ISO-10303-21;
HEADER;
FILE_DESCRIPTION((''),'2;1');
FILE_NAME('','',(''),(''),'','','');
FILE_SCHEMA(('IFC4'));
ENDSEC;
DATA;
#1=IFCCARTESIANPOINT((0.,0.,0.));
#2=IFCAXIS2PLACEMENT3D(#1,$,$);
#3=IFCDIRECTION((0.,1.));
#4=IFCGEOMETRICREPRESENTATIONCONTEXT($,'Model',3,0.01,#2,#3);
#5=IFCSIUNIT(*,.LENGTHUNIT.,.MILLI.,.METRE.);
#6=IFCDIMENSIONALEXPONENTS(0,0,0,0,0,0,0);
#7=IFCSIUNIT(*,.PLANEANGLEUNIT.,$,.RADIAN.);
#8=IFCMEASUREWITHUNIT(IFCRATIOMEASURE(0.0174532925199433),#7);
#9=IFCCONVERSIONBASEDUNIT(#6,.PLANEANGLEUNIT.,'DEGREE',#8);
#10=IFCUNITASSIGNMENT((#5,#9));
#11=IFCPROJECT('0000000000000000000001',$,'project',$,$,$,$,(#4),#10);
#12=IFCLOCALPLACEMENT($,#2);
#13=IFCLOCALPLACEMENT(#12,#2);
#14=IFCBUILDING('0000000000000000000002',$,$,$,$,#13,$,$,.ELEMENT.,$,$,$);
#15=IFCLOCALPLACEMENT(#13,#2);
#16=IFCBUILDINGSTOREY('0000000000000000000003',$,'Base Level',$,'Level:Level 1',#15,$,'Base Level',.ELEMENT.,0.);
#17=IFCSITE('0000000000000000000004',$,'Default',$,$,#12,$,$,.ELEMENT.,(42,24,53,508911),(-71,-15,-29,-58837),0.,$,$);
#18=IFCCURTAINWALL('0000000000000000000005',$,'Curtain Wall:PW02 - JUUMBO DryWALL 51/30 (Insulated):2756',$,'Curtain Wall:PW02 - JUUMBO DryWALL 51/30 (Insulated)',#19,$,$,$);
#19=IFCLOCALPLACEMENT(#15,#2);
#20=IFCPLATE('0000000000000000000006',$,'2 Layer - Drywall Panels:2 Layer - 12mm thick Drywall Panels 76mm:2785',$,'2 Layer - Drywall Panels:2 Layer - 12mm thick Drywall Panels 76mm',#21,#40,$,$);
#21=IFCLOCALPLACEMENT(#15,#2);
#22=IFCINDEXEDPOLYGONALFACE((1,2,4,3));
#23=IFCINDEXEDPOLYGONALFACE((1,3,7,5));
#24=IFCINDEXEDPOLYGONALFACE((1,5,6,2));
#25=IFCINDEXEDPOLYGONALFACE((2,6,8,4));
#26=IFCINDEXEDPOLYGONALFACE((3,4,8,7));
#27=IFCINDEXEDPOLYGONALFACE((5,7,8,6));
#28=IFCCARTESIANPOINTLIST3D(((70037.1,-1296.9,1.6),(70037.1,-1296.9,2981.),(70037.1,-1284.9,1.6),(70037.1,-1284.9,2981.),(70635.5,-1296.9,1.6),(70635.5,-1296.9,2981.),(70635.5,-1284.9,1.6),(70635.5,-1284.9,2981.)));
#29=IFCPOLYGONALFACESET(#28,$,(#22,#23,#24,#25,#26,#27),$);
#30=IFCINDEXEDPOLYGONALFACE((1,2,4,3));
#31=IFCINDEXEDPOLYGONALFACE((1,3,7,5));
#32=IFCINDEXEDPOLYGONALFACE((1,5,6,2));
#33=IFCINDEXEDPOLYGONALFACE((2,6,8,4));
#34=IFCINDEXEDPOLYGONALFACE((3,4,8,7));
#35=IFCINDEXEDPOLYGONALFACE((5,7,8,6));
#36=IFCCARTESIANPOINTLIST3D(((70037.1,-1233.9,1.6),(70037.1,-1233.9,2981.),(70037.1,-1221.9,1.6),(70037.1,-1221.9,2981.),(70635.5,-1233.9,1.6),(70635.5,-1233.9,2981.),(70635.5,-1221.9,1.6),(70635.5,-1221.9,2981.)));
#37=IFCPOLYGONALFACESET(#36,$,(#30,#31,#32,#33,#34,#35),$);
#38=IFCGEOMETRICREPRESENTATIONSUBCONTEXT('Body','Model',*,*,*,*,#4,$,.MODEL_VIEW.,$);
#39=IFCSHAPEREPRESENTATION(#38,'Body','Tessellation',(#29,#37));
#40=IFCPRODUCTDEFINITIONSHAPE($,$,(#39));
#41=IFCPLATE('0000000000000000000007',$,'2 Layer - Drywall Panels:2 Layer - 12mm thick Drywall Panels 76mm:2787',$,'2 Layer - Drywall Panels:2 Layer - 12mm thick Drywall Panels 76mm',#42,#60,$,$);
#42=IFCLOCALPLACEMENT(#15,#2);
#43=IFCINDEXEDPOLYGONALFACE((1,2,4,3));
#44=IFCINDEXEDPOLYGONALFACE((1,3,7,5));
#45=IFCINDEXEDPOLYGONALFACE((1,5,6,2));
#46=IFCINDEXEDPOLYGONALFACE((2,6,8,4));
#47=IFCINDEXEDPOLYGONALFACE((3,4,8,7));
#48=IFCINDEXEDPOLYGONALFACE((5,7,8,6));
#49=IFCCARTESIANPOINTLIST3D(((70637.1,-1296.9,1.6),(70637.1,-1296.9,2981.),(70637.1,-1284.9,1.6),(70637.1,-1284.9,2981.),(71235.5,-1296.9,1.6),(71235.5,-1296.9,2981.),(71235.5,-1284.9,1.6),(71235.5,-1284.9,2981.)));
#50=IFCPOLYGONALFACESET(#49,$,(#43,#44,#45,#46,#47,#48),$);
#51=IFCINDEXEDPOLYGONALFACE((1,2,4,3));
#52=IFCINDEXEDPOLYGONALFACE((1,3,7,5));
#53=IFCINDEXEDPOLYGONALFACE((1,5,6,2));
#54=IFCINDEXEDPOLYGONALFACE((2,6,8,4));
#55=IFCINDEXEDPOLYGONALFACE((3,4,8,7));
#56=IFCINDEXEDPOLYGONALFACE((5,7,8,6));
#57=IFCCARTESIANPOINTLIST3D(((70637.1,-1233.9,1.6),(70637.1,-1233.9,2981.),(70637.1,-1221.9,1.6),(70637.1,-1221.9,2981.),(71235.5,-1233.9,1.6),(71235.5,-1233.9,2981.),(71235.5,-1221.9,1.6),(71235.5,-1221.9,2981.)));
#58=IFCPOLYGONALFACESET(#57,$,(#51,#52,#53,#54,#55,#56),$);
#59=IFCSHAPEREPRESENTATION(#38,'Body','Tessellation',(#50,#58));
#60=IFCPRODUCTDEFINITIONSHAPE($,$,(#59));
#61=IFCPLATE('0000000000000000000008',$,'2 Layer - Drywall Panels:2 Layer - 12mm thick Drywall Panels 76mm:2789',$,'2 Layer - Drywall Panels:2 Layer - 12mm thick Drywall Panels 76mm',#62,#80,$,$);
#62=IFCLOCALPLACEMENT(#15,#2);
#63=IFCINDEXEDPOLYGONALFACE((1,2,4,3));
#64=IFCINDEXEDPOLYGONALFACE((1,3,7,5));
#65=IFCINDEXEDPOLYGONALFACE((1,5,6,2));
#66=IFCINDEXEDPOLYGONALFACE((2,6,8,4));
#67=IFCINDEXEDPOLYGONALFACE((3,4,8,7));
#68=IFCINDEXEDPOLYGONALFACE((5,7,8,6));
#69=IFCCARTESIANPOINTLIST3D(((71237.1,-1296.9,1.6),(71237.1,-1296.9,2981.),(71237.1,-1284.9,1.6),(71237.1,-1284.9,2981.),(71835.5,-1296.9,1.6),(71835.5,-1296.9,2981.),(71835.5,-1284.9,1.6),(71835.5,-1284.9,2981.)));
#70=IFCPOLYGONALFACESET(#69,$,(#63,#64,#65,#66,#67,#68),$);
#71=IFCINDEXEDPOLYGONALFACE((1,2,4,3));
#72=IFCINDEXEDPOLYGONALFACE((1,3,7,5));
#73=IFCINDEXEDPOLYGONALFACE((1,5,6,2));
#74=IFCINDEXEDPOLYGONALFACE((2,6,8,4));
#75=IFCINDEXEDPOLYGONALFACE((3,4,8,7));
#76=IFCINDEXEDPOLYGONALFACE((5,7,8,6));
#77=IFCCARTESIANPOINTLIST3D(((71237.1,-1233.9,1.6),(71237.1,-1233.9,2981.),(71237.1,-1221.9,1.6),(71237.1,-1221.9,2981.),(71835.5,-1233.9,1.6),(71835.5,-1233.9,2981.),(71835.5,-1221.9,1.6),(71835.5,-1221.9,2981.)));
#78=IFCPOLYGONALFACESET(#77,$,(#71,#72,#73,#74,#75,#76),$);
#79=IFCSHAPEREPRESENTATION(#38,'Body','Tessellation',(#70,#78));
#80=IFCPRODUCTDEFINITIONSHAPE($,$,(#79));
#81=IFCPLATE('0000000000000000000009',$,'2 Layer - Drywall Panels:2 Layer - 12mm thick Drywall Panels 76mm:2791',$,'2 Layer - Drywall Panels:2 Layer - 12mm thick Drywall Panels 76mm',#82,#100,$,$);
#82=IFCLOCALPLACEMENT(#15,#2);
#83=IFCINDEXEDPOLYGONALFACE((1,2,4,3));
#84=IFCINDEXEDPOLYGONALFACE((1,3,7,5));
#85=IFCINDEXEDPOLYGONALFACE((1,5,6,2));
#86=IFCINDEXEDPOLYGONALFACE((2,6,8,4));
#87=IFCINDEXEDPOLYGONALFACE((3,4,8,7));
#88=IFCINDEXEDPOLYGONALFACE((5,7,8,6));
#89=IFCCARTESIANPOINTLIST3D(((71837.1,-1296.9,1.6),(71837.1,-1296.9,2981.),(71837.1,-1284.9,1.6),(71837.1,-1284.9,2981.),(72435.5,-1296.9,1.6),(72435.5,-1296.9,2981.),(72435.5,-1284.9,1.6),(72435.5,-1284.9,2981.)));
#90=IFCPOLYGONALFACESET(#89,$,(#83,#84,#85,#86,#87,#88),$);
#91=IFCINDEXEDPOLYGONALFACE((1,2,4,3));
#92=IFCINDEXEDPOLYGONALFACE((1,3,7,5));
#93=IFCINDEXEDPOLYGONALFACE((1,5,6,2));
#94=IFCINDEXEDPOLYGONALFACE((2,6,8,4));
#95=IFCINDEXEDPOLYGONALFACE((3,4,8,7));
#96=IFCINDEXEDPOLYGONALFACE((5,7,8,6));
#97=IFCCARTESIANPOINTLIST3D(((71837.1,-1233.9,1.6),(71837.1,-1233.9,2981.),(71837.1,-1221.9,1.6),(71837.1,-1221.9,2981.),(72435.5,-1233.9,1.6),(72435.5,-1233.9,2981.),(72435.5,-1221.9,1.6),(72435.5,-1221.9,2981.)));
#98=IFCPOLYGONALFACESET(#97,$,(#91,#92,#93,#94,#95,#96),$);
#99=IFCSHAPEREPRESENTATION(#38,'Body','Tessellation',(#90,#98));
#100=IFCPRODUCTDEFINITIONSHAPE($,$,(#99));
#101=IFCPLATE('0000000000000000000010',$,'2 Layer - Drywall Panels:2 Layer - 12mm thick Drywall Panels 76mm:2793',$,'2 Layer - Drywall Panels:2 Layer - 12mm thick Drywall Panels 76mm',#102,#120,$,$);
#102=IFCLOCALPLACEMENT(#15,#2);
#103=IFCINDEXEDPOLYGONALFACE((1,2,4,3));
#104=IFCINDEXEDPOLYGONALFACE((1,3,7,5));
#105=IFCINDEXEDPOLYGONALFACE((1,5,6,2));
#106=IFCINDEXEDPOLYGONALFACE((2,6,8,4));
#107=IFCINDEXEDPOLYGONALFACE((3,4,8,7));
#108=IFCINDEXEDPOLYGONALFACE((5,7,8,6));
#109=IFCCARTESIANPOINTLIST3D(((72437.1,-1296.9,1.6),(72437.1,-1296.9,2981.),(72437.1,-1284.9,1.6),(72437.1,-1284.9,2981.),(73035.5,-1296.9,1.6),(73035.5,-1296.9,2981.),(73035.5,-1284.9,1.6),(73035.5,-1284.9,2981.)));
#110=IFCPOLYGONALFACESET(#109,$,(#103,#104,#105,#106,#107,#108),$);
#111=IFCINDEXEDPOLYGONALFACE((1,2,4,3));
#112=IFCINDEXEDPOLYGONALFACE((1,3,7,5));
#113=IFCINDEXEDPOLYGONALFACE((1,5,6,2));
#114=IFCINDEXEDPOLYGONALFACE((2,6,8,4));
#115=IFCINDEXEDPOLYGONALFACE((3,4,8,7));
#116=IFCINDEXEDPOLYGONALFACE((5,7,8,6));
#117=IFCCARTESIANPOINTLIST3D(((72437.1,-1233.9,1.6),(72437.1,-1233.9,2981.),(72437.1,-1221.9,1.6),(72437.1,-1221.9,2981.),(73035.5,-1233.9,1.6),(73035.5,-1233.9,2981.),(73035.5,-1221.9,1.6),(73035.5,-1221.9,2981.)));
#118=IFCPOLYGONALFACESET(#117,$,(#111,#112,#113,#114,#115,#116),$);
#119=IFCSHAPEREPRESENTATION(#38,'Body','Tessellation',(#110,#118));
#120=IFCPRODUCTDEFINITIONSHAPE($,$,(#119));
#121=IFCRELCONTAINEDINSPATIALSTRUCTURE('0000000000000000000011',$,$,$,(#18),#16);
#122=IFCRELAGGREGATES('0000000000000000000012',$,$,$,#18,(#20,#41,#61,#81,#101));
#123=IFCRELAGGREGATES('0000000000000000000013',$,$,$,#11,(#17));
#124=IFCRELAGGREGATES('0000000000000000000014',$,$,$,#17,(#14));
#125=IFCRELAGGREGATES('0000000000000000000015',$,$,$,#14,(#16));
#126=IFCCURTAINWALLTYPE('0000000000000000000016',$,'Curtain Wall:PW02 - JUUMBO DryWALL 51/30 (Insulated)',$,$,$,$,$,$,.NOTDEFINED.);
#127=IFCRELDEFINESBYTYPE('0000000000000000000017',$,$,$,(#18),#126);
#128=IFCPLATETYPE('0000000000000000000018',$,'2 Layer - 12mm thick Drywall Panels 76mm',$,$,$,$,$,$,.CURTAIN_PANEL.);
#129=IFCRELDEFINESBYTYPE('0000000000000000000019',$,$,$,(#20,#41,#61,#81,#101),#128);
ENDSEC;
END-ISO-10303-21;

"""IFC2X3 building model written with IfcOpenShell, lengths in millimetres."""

from ifc_helpers import new_model, entity, si_unit, converted_unit, direction, frame, frame_2d, origin, origin_2d_with_axis, place, context, subcontext, project, spatial, rectangle, extrude, source, transform, mapped, type_object, type_shapes, element, aggregate, save


model = new_model("IFC2X3")

# Units and contexts
model_context = context("Model", 3, precision=0.01, world=origin(), true_north=direction((0.0, 1.0)))
body_context = subcontext(model_context, "Body", "Model", "MODEL_VIEW")
ifc_project = project(units=[si_unit("LENGTHUNIT", "METRE", prefix="MILLI"), converted_unit("PLANEANGLEUNIT", "DEGREE", entity("IfcRatioMeasure", 0.0174532925199433), si_unit("PLANEANGLEUNIT", "RADIAN"), dimensions=[0, 0, 0, 0, 0, 0, 0])], contexts=[model_context])

# Site, building, storey
site_placement = place(None, origin())
site = spatial("IfcSite", under=ifc_project, at=site_placement, Name="Default", CompositionType="ELEMENT", RefLatitude=(42, 24, 53, 508911), RefLongitude=(-71, -15, -29, -58837), RefElevation=0.0)
building_placement = place(site_placement, origin())
building = spatial("IfcBuilding", under=site, at=building_placement, CompositionType="ELEMENT")
storey_placement = place(building_placement, origin())
storey = spatial("IfcBuildingStorey", under=building, at=storey_placement, Name="Base Level", ObjectType="Level:Level 1", LongName="Base Level", CompositionType="ELEMENT", Elevation=0.0)

# Curtain wall, plates
curtain_wall_type = type_object("IfcCurtainWallType", Name="Curtain Wall:PW02 - JUUMBO DryWALL 51/30 (Insulated)", PredefinedType="NOTDEFINED")
curtain_wall_placement = place(building_placement, origin())
curtain_wall = element("IfcCurtainWall", 1, at=curtain_wall_placement, inside=storey, type_object=curtain_wall_type, Name="Curtain Wall:PW02 - JUUMBO DryWALL 51/30 (Insulated):2756", ObjectType="Curtain Wall:PW02 - JUUMBO DryWALL 51/30 (Insulated)")
plate_type = type_object("IfcPlateType", Name="2 Layer - 12mm thick Drywall Panels 76mm", PredefinedType="CURTAIN_PANEL")
shared_shape_1 = source(origin(), body_context, "Body", "SweptSolid", [
    extrude(rectangle(XDim=598.4, YDim=12.0, at=origin_2d_with_axis()), frame((0.0, -31.5, 0.0), z_axis=(0.0, 0.0, 1.0), x_axis=(-1.0, 0.0, 0.0)), (0.0, 0.0, 1.0), 2979.4),
    extrude(rectangle(XDim=12.0, YDim=598.4, at=frame_2d((0.0, 0.0), x_axis=(1.0, 0.0))), frame((0.0, 31.5, 0.0), z_axis=(0.0, 0.0, 1.0), x_axis=(0.0, 1.0, 0.0)), (0.0, 0.0, 1.0), 2979.4),
])
type_shapes(plate_type, [shared_shape_1])
plate_1_placement = place(curtain_wall_placement, frame((70336.3, -1259.4, 1.6)))
plate_1 = element("IfcPlate", 2, at=plate_1_placement, type_object=plate_type, Name="2 Layer - Drywall Panels:2 Layer - 12mm thick Drywall Panels 76mm:2785", ObjectType="2 Layer - Drywall Panels:2 Layer - 12mm thick Drywall Panels 76mm", context=body_context, shape_type="MappedRepresentation", body=[
    mapped(shared_shape_1, transform((0.0, 0.0, 0.0), scale=1.0)),
])
plate_2_placement = place(curtain_wall_placement, frame((70936.3, -1259.4, 1.6)))
plate_2 = element("IfcPlate", 3, at=plate_2_placement, type_object=plate_type, Name="2 Layer - Drywall Panels:2 Layer - 12mm thick Drywall Panels 76mm:2787", ObjectType="2 Layer - Drywall Panels:2 Layer - 12mm thick Drywall Panels 76mm", context=body_context, shape_type="MappedRepresentation", body=[
    mapped(shared_shape_1, transform((0.0, 0.0, 0.0), scale=1.0)),
])
plate_3_placement = place(curtain_wall_placement, frame((71536.3, -1259.4, 1.6)))
plate_3 = element("IfcPlate", 4, at=plate_3_placement, type_object=plate_type, Name="2 Layer - Drywall Panels:2 Layer - 12mm thick Drywall Panels 76mm:2789", ObjectType="2 Layer - Drywall Panels:2 Layer - 12mm thick Drywall Panels 76mm", context=body_context, shape_type="MappedRepresentation", body=[
    mapped(shared_shape_1, transform((0.0, 0.0, 0.0), scale=1.0)),
])
plate_4_placement = place(curtain_wall_placement, frame((72136.3, -1259.4, 1.6)))
plate_4 = element("IfcPlate", 5, at=plate_4_placement, type_object=plate_type, Name="2 Layer - Drywall Panels:2 Layer - 12mm thick Drywall Panels 76mm:2791", ObjectType="2 Layer - Drywall Panels:2 Layer - 12mm thick Drywall Panels 76mm", context=body_context, shape_type="MappedRepresentation", body=[
    mapped(shared_shape_1, transform((0.0, 0.0, 0.0), scale=1.0)),
])
plate_5_placement = place(curtain_wall_placement, frame((72736.3, -1259.4, 1.6)))
plate_5 = element("IfcPlate", 6, at=plate_5_placement, type_object=plate_type, Name="2 Layer - Drywall Panels:2 Layer - 12mm thick Drywall Panels 76mm:2793", ObjectType="2 Layer - Drywall Panels:2 Layer - 12mm thick Drywall Panels 76mm", context=body_context, shape_type="MappedRepresentation", body=[
    mapped(shared_shape_1, transform((0.0, 0.0, 0.0), scale=1.0)),
])
aggregate(curtain_wall, [plate_1, plate_2, plate_3, plate_4, plate_5])

save(model, "model.ifc")
